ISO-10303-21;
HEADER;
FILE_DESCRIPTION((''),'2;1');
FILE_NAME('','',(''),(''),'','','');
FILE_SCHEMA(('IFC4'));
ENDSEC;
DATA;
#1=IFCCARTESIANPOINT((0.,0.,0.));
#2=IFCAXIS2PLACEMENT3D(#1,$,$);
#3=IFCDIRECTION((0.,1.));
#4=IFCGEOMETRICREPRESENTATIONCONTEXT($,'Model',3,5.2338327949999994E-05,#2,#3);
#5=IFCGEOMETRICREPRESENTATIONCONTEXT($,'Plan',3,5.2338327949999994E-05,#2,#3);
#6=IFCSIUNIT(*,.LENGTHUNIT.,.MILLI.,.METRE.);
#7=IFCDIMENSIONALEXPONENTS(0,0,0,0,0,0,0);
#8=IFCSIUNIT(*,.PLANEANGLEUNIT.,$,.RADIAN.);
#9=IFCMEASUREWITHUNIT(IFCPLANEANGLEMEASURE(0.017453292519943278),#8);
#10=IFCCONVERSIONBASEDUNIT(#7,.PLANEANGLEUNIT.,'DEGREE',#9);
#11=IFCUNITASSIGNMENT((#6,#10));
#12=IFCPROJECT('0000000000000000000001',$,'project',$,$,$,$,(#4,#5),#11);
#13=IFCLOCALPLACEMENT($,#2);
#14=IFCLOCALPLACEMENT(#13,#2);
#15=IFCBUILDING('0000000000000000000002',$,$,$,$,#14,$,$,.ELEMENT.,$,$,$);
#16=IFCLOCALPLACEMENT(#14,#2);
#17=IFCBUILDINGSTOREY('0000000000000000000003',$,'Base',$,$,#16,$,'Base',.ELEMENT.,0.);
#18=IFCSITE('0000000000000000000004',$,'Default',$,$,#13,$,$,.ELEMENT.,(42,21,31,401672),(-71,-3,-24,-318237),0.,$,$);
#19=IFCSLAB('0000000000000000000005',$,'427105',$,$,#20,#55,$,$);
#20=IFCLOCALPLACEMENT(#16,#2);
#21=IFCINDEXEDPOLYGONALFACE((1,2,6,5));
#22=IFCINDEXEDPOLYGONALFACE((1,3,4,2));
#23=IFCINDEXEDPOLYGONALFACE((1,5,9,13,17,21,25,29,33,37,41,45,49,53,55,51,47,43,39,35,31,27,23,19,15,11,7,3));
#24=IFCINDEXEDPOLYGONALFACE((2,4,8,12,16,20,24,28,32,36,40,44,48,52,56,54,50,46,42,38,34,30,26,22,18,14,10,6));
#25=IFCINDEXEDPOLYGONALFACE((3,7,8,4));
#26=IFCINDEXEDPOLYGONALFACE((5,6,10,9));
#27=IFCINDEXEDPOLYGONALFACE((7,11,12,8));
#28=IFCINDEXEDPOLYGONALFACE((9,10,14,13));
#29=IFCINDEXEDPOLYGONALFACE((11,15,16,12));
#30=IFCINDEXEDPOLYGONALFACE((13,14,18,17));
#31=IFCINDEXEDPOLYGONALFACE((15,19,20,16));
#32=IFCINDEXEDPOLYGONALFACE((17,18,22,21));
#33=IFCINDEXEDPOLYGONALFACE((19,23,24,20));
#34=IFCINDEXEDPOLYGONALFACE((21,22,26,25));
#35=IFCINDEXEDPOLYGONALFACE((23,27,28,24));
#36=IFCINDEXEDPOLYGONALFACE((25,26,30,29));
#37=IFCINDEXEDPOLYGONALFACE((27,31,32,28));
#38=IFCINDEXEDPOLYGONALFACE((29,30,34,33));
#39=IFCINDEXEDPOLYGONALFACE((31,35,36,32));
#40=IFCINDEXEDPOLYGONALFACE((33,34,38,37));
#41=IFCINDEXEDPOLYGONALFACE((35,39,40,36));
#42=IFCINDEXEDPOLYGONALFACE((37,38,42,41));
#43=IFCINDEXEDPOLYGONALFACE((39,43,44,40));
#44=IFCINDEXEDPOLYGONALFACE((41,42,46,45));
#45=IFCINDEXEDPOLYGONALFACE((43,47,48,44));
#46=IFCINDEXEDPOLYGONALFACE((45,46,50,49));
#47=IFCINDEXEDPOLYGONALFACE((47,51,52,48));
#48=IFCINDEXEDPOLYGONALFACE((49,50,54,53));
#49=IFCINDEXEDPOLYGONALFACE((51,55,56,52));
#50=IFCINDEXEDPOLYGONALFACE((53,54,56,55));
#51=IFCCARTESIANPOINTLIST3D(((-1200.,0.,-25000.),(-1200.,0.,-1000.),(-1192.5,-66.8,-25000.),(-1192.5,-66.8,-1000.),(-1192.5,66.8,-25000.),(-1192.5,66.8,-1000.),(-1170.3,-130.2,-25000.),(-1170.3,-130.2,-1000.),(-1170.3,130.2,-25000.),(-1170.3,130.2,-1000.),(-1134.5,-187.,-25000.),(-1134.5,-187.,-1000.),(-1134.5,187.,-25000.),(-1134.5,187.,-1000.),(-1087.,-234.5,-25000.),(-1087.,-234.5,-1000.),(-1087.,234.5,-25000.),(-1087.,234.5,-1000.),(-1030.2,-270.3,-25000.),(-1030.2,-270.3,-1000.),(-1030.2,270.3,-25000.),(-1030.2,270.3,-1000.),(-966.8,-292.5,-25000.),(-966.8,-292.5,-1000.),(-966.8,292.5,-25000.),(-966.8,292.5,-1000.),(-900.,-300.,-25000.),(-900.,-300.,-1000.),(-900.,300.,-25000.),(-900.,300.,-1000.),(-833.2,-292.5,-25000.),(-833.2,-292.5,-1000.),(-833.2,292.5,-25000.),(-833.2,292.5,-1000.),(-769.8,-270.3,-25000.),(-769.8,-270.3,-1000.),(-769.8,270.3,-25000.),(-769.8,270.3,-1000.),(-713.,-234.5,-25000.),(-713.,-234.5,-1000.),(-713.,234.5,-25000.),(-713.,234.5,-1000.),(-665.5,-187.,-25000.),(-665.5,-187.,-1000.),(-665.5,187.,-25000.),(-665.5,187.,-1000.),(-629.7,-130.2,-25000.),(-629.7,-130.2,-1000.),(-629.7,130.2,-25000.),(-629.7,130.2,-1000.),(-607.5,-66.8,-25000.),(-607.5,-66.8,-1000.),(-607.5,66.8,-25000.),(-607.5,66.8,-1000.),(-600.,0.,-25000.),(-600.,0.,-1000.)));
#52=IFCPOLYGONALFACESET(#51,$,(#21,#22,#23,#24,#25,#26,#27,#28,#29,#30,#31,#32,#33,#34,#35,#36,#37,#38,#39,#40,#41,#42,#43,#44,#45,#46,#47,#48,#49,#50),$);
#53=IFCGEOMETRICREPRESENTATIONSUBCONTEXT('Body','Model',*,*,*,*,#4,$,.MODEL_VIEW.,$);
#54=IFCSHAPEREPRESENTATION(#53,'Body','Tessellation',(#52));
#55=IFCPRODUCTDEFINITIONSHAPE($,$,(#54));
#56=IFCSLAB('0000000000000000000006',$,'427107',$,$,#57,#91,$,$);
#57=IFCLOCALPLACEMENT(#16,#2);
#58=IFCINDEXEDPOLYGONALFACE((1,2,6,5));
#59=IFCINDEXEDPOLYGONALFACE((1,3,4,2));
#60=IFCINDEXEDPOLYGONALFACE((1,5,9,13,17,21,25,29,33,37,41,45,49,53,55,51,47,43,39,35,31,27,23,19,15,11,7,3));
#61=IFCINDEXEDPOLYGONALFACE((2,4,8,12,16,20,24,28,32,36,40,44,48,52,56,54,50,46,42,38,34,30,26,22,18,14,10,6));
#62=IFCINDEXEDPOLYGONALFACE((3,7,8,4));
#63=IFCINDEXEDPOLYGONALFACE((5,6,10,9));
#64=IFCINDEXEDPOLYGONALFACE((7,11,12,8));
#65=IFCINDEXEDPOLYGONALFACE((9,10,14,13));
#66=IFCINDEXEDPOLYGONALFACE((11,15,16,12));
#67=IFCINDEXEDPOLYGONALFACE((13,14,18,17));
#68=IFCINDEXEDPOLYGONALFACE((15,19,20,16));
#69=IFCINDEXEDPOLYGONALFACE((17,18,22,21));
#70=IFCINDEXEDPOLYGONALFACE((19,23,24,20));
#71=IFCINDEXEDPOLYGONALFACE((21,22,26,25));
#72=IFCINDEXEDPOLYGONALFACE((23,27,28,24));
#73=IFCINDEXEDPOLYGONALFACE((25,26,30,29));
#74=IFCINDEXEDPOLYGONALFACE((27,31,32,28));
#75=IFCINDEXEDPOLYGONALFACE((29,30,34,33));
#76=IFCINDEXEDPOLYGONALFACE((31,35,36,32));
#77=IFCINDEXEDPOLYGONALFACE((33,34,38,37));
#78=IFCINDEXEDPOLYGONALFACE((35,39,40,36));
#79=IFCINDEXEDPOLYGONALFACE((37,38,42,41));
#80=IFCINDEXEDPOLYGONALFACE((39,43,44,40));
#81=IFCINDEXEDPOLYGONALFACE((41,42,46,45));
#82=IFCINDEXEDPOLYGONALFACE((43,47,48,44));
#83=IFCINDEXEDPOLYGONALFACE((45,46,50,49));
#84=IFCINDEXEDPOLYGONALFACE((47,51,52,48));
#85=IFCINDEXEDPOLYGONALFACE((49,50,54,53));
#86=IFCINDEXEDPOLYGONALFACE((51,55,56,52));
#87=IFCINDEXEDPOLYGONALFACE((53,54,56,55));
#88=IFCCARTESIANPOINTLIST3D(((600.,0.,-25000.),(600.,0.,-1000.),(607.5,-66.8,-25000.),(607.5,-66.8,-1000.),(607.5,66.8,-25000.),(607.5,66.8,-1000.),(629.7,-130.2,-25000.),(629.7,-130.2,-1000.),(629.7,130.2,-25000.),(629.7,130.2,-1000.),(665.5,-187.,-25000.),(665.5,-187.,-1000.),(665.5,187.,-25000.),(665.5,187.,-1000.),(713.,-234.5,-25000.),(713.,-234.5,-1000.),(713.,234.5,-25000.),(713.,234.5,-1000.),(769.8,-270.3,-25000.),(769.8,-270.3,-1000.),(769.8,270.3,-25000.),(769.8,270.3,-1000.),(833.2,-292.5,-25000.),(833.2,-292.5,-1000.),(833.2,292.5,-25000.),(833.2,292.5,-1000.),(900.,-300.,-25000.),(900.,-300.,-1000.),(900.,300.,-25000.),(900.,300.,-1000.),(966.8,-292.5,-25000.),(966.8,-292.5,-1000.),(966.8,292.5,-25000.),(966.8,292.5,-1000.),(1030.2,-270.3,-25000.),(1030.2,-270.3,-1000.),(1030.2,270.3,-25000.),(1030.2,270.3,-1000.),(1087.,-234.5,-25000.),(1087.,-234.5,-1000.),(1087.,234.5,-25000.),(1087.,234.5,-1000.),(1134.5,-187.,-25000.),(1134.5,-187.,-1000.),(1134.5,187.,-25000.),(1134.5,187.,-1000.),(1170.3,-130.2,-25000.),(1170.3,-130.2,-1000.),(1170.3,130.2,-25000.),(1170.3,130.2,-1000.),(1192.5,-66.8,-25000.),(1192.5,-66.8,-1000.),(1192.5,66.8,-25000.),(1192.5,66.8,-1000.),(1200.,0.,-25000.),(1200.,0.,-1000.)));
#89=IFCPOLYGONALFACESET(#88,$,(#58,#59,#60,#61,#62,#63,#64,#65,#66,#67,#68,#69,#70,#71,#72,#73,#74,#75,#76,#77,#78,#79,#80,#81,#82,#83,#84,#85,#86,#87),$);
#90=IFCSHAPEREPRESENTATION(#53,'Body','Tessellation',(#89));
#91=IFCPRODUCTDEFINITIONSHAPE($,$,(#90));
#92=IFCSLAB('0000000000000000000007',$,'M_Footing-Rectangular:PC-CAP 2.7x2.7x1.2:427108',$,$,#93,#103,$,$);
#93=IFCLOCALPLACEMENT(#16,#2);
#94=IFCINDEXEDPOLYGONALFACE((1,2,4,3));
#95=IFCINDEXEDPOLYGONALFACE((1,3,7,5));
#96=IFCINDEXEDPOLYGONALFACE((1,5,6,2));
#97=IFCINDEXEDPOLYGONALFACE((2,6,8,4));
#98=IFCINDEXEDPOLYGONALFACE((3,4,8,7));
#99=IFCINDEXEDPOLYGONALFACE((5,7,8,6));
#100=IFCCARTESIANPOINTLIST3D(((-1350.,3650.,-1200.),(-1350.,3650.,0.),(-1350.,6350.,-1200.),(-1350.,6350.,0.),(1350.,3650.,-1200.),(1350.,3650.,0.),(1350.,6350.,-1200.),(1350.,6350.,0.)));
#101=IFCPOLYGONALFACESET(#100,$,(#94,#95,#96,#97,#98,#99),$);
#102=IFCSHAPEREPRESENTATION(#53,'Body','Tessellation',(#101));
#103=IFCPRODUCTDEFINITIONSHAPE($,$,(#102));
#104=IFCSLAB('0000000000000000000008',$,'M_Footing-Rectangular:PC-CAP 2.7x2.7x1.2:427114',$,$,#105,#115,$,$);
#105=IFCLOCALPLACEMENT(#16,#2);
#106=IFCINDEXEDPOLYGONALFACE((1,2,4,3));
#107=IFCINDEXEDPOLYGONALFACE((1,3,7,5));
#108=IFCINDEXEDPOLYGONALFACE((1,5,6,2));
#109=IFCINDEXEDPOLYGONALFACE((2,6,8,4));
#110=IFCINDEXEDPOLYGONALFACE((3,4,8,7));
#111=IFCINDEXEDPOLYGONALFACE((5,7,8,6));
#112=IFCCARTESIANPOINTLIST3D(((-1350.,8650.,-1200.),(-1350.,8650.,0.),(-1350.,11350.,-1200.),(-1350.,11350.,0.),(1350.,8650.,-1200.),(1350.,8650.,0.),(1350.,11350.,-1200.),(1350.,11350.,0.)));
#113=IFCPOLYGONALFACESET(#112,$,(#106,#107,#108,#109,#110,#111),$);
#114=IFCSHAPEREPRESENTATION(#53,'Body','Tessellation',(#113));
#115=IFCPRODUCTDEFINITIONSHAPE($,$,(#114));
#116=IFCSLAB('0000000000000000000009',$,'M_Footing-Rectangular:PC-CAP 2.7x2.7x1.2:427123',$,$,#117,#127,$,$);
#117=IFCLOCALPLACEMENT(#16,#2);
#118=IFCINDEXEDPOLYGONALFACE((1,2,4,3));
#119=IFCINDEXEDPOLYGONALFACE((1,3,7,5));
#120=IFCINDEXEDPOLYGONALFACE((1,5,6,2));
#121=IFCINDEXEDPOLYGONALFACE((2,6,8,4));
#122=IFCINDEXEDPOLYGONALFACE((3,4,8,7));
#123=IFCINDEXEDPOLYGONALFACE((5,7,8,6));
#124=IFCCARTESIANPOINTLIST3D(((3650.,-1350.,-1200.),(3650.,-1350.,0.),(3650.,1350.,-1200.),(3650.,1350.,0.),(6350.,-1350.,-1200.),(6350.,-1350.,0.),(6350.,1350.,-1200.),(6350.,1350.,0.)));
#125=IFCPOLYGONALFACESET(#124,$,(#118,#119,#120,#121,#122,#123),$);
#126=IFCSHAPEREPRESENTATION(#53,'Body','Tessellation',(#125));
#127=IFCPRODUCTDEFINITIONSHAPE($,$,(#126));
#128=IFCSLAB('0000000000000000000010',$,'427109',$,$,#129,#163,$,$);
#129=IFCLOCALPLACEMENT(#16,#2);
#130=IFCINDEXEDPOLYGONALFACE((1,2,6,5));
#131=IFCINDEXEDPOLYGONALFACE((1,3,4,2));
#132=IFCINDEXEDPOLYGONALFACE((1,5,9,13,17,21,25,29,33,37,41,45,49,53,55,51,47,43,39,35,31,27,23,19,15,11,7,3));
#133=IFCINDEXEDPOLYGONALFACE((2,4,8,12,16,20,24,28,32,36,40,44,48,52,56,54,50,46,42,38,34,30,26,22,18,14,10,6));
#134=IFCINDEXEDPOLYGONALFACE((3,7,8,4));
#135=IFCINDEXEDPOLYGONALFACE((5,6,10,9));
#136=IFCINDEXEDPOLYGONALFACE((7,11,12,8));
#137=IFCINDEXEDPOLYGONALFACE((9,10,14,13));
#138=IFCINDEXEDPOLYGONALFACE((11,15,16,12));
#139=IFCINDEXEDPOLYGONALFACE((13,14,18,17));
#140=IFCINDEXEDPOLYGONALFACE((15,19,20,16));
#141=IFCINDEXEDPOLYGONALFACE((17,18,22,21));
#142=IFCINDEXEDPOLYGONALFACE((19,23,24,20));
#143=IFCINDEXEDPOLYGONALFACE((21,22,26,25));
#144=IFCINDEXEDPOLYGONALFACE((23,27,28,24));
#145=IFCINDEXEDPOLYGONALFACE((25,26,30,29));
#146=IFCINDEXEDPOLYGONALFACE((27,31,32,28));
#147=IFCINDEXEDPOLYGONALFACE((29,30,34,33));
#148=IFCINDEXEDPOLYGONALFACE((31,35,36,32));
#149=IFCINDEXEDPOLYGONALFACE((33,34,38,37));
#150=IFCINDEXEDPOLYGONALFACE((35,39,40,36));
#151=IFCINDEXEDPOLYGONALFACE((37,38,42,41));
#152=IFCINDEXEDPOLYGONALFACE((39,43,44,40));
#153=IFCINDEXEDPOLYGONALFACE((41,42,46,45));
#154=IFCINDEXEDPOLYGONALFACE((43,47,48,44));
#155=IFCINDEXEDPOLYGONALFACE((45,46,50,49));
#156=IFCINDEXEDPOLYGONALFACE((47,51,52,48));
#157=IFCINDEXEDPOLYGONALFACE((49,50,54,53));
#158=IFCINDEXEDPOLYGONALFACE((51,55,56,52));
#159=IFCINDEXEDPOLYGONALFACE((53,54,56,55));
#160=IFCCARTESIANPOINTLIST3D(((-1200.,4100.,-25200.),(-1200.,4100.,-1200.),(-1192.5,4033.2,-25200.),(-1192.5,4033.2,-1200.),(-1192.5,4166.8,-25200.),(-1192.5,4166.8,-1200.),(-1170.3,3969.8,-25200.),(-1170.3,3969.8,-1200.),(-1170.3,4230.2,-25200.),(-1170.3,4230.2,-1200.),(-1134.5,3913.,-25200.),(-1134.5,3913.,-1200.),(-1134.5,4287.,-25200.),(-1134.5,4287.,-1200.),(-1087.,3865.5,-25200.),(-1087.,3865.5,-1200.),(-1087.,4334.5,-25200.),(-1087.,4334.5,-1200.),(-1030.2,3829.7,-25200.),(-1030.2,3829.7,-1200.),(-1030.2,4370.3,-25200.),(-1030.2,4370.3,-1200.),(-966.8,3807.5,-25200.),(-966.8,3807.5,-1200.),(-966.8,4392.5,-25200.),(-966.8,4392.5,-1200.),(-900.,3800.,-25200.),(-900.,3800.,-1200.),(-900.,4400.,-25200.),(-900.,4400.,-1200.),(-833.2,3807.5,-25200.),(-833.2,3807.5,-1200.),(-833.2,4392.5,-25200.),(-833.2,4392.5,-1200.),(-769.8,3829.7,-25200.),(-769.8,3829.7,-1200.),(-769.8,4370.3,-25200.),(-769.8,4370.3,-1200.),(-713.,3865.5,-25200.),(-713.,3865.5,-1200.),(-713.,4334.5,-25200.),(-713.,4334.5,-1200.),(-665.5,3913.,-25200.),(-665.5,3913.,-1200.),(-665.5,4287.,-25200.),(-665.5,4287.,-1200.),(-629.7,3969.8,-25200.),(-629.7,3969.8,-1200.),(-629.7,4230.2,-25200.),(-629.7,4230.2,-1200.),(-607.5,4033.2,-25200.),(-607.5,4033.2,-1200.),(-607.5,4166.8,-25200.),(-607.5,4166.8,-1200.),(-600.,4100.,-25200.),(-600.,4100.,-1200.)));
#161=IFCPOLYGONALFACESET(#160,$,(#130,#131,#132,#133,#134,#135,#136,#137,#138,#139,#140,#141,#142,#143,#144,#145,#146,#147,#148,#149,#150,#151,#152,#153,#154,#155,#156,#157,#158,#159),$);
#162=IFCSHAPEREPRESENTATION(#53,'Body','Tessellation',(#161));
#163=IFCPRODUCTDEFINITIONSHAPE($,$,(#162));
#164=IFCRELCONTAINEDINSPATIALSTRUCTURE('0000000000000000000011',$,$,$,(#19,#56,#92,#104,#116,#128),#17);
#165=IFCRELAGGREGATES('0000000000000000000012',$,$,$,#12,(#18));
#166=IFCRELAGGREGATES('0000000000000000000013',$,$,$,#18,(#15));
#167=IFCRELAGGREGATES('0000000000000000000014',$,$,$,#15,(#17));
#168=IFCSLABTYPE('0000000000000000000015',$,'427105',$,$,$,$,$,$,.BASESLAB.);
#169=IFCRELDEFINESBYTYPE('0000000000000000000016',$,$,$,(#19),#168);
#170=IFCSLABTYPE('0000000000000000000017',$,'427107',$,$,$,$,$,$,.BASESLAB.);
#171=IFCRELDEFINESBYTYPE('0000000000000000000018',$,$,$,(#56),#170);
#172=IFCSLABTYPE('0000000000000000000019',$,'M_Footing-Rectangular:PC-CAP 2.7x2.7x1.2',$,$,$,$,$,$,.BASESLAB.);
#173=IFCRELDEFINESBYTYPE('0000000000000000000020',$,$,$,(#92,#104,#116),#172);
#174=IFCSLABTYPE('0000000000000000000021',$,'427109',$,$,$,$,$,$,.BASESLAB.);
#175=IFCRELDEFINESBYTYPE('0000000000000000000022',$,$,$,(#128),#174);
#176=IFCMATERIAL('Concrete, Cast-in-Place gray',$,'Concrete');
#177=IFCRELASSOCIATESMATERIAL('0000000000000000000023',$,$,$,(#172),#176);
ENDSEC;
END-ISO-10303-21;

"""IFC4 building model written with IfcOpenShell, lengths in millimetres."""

from ifc_helpers import new_model, entity, si_unit, converted_unit, direction, frame, origin, place, context, subcontext, project, spatial, arc, indexed_curve, outline, extrude, material, type_object, element, save


model = new_model("IFC4")

# Units and contexts
model_context = context("Model", 3, precision=5.2338327949999994e-05, world=origin(), true_north=direction((0.0, 1.0)))
plan_context = context("Plan", 3, precision=5.2338327949999994e-05, world=origin(), true_north=direction((0.0, 1.0)))
body_context = subcontext(model_context, "Body", "Model", "MODEL_VIEW")
ifc_project = project(units=[si_unit("LENGTHUNIT", "METRE", prefix="MILLI"), converted_unit("PLANEANGLEUNIT", "DEGREE", entity("IfcPlaneAngleMeasure", 0.017453292519943278), si_unit("PLANEANGLEUNIT", "RADIAN"), dimensions=[0, 0, 0, 0, 0, 0, 0])], contexts=[model_context, plan_context])

# Site, building, storey
site_placement = place(None, origin())
site = spatial("IfcSite", under=ifc_project, at=site_placement, Name="Default", CompositionType="ELEMENT", RefLatitude=(42, 21, 31, 401672), RefLongitude=(-71, -3, -24, -318237), RefElevation=0.0)
building_placement = place(site_placement, origin())
building = spatial("IfcBuilding", under=site, at=building_placement, CompositionType="ELEMENT")
storey_placement = place(building_placement, origin())
storey = spatial("IfcBuildingStorey", under=building, at=storey_placement, Name="Base", LongName="Base", CompositionType="ELEMENT", Elevation=0.0)

# Slabs
ifc_material_1 = material(Name="Concrete, Cast-in-Place gray", Category="Concrete")
slab_type_1 = type_object("IfcSlabType", Name="427105", PredefinedType="BASESLAB")
slab_1_placement = place(storey_placement, origin())
element("IfcSlab", 1, at=slab_1_placement, inside=storey, type_object=slab_type_1, Name="427105", context=body_context, shape_type="SweptSolid", body=[
    extrude(outline(indexed_curve([(300.0, 0.0), (0.0, 300.0), (-300.0, 0.0), (0.0, -300.0)], segments=[arc(1, 2, 3), arc(3, 4, 1)], self_intersect=False)), frame((-900.0, 0.0, -25000.0)), (0.0, 0.0, 1.0), 24000.0),
])
slab_type_2 = type_object("IfcSlabType", Name="427107", PredefinedType="BASESLAB")
slab_2_placement = place(storey_placement, origin())
element("IfcSlab", 2, at=slab_2_placement, inside=storey, type_object=slab_type_2, Name="427107", context=body_context, shape_type="SweptSolid", body=[
    extrude(outline(indexed_curve([(300.0, 0.0), (0.0, 300.0), (-300.0, 0.0), (0.0, -300.0)], segments=[arc(1, 2, 3), arc(3, 4, 1)], self_intersect=False)), frame((900.0, 0.0, -25000.0)), (0.0, 0.0, 1.0), 24000.0),
])
slab_type_3 = type_object("IfcSlabType", Name="M_Footing-Rectangular:PC-CAP 2.7x2.7x1.2", PredefinedType="BASESLAB", material=ifc_material_1)
slab_3_placement = place(storey_placement, origin())
element("IfcSlab", 3, at=slab_3_placement, inside=storey, type_object=slab_type_3, Name="M_Footing-Rectangular:PC-CAP 2.7x2.7x1.2:427108", context=body_context, shape_type="SweptSolid", body=[
    extrude(outline(indexed_curve([(-1350.0, -1350.0), (1350.0, -1350.0), (1350.0, 1350.0), (-1350.0, 1350.0), (-1350.0, -1350.0)], self_intersect=False)), frame((0.0, 5000.0, -1200.0), z_axis=(0.0, 0.0, 1.0), x_axis=(-1.0, 0.0, 0.0)), (0.0, 0.0, 1.0), 1200.0),
])
slab_4_placement = place(storey_placement, origin())
element("IfcSlab", 4, at=slab_4_placement, inside=storey, type_object=slab_type_3, Name="M_Footing-Rectangular:PC-CAP 2.7x2.7x1.2:427114", context=body_context, shape_type="SweptSolid", body=[
    extrude(outline(indexed_curve([(-1350.0, -1350.0), (1350.0, -1350.0), (1350.0, 1350.0), (-1350.0, 1350.0), (-1350.0, -1350.0)], self_intersect=False)), frame((0.0, 10000.0, -1200.0), z_axis=(0.0, 0.0, 1.0), x_axis=(-1.0, 0.0, 0.0)), (0.0, 0.0, 1.0), 1200.0),
])
slab_5_placement = place(storey_placement, origin())
element("IfcSlab", 5, at=slab_5_placement, inside=storey, type_object=slab_type_3, Name="M_Footing-Rectangular:PC-CAP 2.7x2.7x1.2:427123", context=body_context, shape_type="SweptSolid", body=[
    extrude(outline(indexed_curve([(-1350.0, -1350.0), (1350.0, -1350.0), (1350.0, 1350.0), (-1350.0, 1350.0), (-1350.0, -1350.0)], self_intersect=False)), frame((5000.0, 0.0, -1200.0), z_axis=(0.0, 0.0, 1.0), x_axis=(-1.0, 0.0, 0.0)), (0.0, 0.0, 1.0), 1200.0),
])
slab_type_4 = type_object("IfcSlabType", Name="427109", PredefinedType="BASESLAB")
slab_6_placement = place(storey_placement, origin())
element("IfcSlab", 6, at=slab_6_placement, inside=storey, type_object=slab_type_4, Name="427109", context=body_context, shape_type="SweptSolid", body=[
    extrude(outline(indexed_curve([(300.0, 0.0), (0.0, 300.0), (-300.0, 0.0), (0.0, -300.0)], segments=[arc(1, 2, 3), arc(3, 4, 1)], self_intersect=False)), frame((-900.0, 4100.0, -25200.0)), (0.0, 0.0, 1.0), 24000.0),
])

save(model, "model.ifc")
